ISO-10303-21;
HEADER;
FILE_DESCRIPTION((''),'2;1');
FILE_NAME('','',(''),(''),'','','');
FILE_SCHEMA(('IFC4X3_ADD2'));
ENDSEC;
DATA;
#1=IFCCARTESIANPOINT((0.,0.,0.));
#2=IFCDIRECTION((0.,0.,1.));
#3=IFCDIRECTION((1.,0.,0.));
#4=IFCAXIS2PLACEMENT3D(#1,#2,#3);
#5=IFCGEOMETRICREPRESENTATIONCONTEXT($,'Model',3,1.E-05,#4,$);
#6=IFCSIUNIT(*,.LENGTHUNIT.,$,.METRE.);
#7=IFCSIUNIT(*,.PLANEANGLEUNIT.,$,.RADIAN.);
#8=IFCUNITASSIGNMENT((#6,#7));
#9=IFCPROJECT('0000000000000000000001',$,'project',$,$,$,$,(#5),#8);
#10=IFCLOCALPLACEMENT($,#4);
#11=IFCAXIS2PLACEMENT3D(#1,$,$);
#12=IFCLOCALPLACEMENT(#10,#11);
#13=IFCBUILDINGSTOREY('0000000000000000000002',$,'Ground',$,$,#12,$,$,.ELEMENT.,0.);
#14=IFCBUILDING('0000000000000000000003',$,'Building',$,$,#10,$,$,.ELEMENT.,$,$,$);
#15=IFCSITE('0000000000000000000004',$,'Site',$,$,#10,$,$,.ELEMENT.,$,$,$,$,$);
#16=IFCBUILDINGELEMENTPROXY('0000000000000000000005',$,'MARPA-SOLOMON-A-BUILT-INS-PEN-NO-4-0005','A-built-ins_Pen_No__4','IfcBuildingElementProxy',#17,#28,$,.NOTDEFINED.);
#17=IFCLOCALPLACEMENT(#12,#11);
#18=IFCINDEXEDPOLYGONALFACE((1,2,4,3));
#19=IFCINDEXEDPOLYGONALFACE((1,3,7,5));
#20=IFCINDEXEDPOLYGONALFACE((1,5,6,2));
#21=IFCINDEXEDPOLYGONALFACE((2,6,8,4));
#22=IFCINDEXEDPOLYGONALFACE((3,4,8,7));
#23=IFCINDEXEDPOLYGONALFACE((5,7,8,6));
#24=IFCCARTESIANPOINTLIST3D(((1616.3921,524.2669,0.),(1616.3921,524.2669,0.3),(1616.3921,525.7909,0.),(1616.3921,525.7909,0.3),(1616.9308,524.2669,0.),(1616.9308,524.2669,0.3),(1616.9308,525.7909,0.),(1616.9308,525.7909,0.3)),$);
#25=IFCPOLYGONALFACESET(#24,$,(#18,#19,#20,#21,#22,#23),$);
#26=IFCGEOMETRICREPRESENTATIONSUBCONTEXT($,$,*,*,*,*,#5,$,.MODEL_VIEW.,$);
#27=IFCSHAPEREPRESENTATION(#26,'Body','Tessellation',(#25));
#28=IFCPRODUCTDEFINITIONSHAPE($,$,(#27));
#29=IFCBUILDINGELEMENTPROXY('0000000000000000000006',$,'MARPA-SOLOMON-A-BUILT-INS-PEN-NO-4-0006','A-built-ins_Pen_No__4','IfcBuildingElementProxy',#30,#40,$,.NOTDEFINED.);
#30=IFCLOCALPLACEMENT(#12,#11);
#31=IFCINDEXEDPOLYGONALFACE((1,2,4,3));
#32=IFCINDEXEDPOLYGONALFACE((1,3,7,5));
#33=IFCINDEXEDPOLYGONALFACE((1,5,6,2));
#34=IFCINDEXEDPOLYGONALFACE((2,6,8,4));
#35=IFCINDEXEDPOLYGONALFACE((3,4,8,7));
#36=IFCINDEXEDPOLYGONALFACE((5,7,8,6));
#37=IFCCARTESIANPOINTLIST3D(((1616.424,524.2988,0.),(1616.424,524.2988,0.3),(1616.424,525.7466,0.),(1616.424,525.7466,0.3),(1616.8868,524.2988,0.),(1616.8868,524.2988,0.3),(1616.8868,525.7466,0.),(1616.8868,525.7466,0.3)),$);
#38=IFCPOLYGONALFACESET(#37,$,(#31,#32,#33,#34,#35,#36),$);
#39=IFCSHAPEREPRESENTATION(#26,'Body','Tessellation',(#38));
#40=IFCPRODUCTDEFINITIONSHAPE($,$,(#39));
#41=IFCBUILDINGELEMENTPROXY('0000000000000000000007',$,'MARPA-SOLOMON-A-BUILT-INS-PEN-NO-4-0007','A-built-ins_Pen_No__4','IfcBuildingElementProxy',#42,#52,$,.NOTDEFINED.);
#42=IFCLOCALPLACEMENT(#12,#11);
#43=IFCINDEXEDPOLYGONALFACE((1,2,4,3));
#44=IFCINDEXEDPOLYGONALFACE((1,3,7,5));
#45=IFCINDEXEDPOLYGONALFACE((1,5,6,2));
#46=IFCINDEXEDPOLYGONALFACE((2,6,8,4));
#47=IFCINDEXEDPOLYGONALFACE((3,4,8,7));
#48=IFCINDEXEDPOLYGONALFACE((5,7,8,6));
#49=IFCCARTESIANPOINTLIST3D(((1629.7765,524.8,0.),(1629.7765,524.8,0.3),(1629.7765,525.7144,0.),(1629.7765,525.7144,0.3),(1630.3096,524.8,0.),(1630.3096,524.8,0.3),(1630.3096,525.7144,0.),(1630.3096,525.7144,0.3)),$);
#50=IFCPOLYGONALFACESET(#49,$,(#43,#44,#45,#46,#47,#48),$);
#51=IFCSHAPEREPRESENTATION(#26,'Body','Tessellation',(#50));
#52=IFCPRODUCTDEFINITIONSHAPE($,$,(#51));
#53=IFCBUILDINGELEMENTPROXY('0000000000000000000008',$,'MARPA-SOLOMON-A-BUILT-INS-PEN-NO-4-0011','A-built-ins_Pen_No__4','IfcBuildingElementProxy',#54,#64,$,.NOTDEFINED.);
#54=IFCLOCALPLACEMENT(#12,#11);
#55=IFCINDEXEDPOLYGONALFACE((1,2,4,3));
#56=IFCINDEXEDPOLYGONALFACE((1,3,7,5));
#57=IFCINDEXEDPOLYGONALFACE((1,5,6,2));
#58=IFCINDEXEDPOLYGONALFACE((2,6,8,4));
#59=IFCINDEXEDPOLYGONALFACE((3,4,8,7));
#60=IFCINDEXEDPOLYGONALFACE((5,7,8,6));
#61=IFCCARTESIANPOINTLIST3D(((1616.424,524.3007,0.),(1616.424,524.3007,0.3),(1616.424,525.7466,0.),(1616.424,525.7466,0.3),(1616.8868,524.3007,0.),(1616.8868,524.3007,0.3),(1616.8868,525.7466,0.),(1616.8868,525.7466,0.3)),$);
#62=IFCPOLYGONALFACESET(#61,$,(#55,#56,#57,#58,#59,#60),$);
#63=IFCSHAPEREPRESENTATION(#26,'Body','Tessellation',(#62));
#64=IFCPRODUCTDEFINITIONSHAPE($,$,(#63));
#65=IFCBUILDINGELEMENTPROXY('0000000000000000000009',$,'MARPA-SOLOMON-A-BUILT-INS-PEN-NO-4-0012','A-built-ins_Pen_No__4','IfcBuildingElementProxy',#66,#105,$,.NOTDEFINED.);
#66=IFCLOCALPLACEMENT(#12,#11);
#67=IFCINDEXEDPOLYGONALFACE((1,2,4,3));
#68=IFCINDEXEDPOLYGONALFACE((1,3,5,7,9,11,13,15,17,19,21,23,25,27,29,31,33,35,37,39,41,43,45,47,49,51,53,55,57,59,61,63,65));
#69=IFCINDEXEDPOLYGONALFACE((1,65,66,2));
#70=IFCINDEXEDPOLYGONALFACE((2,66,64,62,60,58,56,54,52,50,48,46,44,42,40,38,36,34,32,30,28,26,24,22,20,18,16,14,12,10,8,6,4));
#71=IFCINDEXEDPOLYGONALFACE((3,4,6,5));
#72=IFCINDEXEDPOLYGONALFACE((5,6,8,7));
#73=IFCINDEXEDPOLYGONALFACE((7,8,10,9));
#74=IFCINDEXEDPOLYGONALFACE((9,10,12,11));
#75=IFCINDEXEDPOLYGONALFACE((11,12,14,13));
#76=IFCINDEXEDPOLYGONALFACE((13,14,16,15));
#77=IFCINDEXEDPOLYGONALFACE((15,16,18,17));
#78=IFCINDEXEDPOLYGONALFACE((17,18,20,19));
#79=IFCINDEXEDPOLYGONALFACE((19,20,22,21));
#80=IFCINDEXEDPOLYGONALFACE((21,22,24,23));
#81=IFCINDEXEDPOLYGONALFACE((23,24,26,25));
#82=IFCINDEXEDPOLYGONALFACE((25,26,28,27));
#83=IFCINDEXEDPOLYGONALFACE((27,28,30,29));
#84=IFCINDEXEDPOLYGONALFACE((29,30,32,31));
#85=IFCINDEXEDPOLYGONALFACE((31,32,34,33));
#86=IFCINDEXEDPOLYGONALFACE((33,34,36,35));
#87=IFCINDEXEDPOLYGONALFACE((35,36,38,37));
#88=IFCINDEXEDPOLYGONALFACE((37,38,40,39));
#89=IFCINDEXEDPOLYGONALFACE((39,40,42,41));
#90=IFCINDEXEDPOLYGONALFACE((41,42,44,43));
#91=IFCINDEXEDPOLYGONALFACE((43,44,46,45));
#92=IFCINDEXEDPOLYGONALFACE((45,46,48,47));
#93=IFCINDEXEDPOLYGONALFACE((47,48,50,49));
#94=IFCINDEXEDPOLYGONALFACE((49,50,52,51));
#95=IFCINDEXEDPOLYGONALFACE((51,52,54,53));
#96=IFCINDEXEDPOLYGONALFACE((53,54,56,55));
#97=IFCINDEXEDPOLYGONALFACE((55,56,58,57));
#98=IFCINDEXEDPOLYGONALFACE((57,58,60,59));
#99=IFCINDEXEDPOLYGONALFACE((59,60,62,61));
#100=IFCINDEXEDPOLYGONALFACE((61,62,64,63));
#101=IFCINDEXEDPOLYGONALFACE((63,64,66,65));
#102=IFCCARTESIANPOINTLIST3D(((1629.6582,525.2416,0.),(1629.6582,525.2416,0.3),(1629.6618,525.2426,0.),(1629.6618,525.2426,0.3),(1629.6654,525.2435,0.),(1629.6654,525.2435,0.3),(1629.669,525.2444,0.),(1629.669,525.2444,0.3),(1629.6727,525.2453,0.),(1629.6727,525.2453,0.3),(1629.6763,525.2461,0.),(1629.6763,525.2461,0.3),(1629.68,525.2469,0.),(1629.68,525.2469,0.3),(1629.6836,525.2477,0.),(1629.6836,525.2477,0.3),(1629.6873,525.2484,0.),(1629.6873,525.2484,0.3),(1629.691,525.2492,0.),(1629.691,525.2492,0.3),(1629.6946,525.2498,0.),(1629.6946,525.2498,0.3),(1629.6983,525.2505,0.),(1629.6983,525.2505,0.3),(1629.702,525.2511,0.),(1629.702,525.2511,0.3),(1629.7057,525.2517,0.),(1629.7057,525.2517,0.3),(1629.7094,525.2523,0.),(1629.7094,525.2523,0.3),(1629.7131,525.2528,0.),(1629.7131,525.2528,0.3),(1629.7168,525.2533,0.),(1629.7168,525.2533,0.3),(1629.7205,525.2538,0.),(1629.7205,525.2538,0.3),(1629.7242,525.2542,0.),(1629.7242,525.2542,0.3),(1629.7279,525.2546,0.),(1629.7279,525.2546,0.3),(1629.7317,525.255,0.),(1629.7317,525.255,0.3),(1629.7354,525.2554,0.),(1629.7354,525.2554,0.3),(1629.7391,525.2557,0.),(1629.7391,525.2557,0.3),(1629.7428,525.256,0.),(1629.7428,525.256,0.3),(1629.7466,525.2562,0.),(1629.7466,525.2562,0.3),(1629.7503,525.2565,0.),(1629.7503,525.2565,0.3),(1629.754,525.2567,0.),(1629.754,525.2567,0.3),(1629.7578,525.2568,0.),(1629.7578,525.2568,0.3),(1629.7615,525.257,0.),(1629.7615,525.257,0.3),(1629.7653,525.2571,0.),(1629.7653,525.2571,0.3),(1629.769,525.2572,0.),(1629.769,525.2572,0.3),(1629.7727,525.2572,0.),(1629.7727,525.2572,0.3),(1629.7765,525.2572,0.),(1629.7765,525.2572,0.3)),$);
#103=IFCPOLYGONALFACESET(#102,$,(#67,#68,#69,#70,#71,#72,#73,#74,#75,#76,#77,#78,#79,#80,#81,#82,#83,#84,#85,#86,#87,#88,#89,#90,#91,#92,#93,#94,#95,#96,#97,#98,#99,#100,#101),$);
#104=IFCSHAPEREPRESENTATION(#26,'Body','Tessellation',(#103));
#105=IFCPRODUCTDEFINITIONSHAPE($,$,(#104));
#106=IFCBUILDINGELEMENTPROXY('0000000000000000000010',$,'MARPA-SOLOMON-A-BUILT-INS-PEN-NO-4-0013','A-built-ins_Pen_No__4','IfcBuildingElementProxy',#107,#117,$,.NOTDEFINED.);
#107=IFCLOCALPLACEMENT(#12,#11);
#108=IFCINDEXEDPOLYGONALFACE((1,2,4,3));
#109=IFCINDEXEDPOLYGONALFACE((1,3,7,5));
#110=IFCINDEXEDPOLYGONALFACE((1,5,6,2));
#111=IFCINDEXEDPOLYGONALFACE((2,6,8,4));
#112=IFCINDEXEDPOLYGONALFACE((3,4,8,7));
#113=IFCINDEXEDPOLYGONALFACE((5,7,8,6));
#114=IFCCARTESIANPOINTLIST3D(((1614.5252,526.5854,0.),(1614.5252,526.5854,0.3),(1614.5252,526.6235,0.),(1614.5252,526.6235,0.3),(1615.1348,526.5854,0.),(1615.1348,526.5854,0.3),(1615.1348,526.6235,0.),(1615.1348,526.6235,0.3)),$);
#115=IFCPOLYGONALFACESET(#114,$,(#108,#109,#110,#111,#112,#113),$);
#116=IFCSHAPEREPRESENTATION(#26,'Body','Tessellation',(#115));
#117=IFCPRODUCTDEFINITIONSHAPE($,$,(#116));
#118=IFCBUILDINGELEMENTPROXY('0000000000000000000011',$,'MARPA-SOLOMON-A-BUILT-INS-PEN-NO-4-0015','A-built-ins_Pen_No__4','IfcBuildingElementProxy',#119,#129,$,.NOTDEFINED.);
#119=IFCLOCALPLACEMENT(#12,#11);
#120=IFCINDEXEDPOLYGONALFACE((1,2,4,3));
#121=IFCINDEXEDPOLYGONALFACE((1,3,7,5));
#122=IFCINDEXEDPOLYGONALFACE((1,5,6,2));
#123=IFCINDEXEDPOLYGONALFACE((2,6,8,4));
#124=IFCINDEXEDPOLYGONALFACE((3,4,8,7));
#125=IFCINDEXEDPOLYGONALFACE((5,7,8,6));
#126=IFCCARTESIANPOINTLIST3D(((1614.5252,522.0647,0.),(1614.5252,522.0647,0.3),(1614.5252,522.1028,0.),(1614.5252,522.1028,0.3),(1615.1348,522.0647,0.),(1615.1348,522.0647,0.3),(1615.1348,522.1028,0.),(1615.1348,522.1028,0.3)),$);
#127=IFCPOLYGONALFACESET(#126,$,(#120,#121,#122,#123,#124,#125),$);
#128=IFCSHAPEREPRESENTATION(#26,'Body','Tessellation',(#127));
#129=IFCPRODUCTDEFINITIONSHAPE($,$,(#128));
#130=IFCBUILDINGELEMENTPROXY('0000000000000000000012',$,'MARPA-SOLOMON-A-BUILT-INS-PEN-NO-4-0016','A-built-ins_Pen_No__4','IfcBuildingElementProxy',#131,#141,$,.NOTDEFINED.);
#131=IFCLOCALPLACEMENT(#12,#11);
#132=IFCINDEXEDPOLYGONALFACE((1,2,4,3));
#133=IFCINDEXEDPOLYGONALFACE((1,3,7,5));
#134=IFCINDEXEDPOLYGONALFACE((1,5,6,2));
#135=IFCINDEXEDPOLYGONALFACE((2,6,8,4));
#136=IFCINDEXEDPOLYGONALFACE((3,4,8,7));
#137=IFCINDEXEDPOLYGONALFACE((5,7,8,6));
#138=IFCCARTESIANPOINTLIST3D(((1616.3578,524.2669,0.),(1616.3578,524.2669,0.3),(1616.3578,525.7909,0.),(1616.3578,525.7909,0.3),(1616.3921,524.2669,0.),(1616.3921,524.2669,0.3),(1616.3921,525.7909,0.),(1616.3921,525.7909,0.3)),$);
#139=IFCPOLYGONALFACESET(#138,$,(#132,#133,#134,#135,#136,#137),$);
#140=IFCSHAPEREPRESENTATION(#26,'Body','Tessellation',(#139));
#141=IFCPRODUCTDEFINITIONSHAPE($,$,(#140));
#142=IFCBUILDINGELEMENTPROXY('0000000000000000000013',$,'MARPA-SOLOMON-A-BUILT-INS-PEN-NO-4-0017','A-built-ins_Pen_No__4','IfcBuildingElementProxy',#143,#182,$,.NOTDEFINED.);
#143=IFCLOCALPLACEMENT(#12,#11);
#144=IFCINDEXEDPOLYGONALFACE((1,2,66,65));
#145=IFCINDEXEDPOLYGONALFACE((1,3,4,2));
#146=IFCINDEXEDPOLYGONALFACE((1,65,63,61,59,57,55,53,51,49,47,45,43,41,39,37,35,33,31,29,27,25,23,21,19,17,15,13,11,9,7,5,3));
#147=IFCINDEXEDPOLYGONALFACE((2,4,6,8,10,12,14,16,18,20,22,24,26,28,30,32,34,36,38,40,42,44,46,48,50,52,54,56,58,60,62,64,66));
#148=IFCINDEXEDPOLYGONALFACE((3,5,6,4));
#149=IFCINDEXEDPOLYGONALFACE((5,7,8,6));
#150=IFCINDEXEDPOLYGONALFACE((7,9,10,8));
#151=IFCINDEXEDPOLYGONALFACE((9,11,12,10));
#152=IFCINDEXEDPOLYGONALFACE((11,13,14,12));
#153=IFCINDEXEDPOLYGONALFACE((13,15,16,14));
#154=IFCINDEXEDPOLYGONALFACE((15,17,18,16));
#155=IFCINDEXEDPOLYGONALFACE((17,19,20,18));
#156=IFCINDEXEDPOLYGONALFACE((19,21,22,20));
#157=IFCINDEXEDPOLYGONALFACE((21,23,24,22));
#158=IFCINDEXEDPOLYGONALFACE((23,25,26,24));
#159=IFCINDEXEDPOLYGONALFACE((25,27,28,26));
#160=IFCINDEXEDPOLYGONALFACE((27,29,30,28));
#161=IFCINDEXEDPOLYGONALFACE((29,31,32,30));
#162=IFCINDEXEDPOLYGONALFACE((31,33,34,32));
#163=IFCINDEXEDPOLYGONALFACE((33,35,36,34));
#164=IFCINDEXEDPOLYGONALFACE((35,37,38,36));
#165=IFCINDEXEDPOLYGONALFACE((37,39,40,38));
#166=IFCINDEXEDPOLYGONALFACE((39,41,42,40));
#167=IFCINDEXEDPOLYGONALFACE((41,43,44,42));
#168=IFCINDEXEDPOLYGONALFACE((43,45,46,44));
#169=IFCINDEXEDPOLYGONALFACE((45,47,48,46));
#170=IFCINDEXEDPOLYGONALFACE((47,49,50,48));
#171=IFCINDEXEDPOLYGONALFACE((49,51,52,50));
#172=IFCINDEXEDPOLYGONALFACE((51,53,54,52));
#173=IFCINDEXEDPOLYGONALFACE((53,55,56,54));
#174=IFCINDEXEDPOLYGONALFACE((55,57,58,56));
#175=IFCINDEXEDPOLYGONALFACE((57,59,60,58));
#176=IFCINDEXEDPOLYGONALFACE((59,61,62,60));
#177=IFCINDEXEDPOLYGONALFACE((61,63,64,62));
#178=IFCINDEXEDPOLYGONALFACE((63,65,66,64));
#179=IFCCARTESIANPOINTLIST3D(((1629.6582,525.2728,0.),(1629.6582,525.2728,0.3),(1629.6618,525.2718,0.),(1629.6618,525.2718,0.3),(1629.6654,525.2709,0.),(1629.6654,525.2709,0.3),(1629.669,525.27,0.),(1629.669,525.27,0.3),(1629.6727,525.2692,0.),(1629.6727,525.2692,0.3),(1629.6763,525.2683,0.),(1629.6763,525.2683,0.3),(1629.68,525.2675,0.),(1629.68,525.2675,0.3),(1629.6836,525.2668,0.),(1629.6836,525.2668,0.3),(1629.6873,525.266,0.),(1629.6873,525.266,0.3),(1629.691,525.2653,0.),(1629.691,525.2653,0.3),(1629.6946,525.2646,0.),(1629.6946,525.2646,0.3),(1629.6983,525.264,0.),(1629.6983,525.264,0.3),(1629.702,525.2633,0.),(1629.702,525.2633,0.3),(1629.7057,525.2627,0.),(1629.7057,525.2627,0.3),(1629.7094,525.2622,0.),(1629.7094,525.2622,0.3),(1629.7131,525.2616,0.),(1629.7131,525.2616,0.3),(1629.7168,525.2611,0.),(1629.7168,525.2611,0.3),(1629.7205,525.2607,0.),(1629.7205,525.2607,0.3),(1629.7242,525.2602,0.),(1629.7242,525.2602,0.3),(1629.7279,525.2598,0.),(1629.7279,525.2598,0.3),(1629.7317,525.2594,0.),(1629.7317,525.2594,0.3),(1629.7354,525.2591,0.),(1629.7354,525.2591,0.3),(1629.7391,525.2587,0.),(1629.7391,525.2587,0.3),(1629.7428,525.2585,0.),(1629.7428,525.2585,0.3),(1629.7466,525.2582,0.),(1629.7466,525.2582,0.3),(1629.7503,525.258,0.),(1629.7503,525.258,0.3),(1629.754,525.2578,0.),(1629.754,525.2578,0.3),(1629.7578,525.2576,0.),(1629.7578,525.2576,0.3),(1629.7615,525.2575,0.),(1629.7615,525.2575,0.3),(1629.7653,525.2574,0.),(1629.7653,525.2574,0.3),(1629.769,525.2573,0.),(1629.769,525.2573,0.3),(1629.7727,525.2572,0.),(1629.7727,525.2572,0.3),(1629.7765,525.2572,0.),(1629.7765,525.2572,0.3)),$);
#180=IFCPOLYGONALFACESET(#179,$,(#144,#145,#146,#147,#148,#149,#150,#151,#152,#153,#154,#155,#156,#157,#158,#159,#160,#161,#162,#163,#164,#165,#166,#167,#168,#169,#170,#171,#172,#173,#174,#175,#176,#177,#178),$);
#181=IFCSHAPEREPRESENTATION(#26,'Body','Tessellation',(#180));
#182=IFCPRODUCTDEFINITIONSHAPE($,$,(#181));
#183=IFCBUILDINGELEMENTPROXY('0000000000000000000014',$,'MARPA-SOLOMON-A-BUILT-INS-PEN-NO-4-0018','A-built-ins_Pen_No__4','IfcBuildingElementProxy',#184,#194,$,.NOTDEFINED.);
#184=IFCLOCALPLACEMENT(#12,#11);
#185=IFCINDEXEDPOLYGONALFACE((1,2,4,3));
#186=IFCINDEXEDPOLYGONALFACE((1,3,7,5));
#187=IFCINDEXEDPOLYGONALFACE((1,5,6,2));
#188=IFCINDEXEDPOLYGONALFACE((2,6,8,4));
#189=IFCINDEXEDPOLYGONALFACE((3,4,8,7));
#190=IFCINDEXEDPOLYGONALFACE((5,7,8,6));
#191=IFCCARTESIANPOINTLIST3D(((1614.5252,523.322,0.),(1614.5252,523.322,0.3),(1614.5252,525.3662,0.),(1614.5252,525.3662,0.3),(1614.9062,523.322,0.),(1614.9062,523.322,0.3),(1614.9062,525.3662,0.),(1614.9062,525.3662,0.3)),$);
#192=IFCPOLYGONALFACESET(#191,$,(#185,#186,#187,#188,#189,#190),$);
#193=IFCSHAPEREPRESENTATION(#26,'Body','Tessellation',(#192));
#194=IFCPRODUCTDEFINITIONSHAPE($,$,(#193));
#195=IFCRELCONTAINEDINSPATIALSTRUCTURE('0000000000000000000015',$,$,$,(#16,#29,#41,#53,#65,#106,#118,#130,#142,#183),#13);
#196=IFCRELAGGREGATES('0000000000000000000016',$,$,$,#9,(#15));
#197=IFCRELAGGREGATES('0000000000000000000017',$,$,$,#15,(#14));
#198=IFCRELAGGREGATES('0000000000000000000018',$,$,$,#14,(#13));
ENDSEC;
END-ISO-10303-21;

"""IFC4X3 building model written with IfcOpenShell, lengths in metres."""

from ifc_helpers import new_model, si_unit, frame, origin, origin_with_axes, place, context, subcontext, project, spatial, polyline, outline, extrude, element, save


model = new_model("IFC4X3")

# Units and contexts
model_context = context("Model", 3, precision=1e-05, world=origin_with_axes())
sub_context = subcontext(model_context, None, None, "MODEL_VIEW")
ifc_project = project(units=[si_unit("LENGTHUNIT", "METRE"), si_unit("PLANEANGLEUNIT", "RADIAN")], contexts=[model_context])

# Site, building, storey
placement = place(None, origin_with_axes())
site = spatial("IfcSite", under=ifc_project, at=placement, Name="Site", CompositionType="ELEMENT")
building = spatial("IfcBuilding", under=site, at=placement, Name="Building", CompositionType="ELEMENT")
storey_placement = place(placement, origin())
storey = spatial("IfcBuildingStorey", under=building, at=storey_placement, Name="Ground", CompositionType="ELEMENT", Elevation=0.0)

# Building element proxies
proxy_1_placement = place(placement, frame((1616.3921, 524.2669, 0.0)))
element("IfcBuildingElementProxy", 1, at=proxy_1_placement, inside=storey, Name="MARPA-SOLOMON-A-BUILT-INS-PEN-NO-4-0005", Description="A-built-ins_Pen_No__4", ObjectType="IfcBuildingElementProxy", PredefinedType="NOTDEFINED", context=sub_context, shape_type="SweptSolid", body=[
    extrude(outline(polyline([(0.0, 0.0), (0.0, 1.524), (0.5387, 1.524), (0.5387, 0.0), (0.0, 0.0)])), origin(), (0.0, 0.0, 1.0), 0.3),
])
proxy_2_placement = place(placement, frame((1616.424, 524.2988, 0.0)))
element("IfcBuildingElementProxy", 2, at=proxy_2_placement, inside=storey, Name="MARPA-SOLOMON-A-BUILT-INS-PEN-NO-4-0006", Description="A-built-ins_Pen_No__4", ObjectType="IfcBuildingElementProxy", PredefinedType="NOTDEFINED", context=sub_context, shape_type="SweptSolid", body=[
    extrude(outline(polyline([(0.0, 0.0), (0.0, 1.4478), (0.4628, 1.4478), (0.4628, 0.0), (0.0, 0.0)])), origin(), (0.0, 0.0, 1.0), 0.3),
])
proxy_3_placement = place(placement, frame((1629.7765, 524.8, 0.0)))
element("IfcBuildingElementProxy", 3, at=proxy_3_placement, inside=storey, Name="MARPA-SOLOMON-A-BUILT-INS-PEN-NO-4-0007", Description="A-built-ins_Pen_No__4", ObjectType="IfcBuildingElementProxy", PredefinedType="NOTDEFINED", context=sub_context, shape_type="SweptSolid", body=[
    extrude(outline(polyline([(0.0, 0.9144), (0.0, 0.0), (0.5331, 0.0), (0.5331, 0.9144), (0.0, 0.9144)])), origin(), (0.0, 0.0, 1.0), 0.3),
])
proxy_4_placement = place(placement, frame((1616.424, 524.3007, 0.0)))
element("IfcBuildingElementProxy", 4, at=proxy_4_placement, inside=storey, Name="MARPA-SOLOMON-A-BUILT-INS-PEN-NO-4-0011", Description="A-built-ins_Pen_No__4", ObjectType="IfcBuildingElementProxy", PredefinedType="NOTDEFINED", context=sub_context, shape_type="SweptSolid", body=[
    extrude(outline(polyline([(0.0, 0.0), (0.0, 1.4459), (0.4628, 1.4459), (0.4628, 0.0), (0.0, 0.0)])), origin(), (0.0, 0.0, 1.0), 0.3),
])
proxy_5_placement = place(placement, frame((1629.6582, 525.2416, 0.0)))
element("IfcBuildingElementProxy", 5, at=proxy_5_placement, inside=storey, Name="MARPA-SOLOMON-A-BUILT-INS-PEN-NO-4-0012", Description="A-built-ins_Pen_No__4", ObjectType="IfcBuildingElementProxy", PredefinedType="NOTDEFINED", context=sub_context, shape_type="SweptSolid", body=[
    extrude(outline(polyline([(0.0, 0.0), (0.0036, 0.001), (0.0072, 0.0019), (0.0109, 0.0028), (0.0145, 0.0036), (0.0182, 0.0045), (0.0218, 0.0053), (0.0255, 0.006), (0.0291, 0.0068), (0.0328, 0.0075), (0.0365, 0.0082), (0.0402, 0.0088), (0.0439, 0.0095), (0.0475, 0.0101), (0.0512, 0.0106), (0.0549, 0.0112), (0.0587, 0.0117), (0.0624, 0.0121), (0.0661, 0.0126), (0.0698, 0.013), (0.0735, 0.0134), (0.0772, 0.0137), (0.081, 0.014), (0.0847, 0.0143), (0.0884, 0.0146), (0.0922, 0.0148), (0.0959, 0.015), (0.0996, 0.0152), (0.1034, 0.0153), (0.1071, 0.0154), (0.1109, 0.0155), (0.1146, 0.0156), (0.1183, 0.0156), (0.0, 0.0)])), origin(), (0.0, 0.0, 1.0), 0.3),
])
proxy_6_placement = place(placement, frame((1614.5252, 526.5854, 0.0)))
element("IfcBuildingElementProxy", 6, at=proxy_6_placement, inside=storey, Name="MARPA-SOLOMON-A-BUILT-INS-PEN-NO-4-0013", Description="A-built-ins_Pen_No__4", ObjectType="IfcBuildingElementProxy", PredefinedType="NOTDEFINED", context=sub_context, shape_type="SweptSolid", body=[
    extrude(outline(polyline([(0.6096, 0.0381), (0.6096, 0.0), (0.0, 0.0), (0.0, 0.0381), (0.6096, 0.0381)])), origin(), (0.0, 0.0, 1.0), 0.3),
])
proxy_7_placement = place(placement, frame((1614.5252, 522.0647, 0.0)))
element("IfcBuildingElementProxy", 7, at=proxy_7_placement, inside=storey, Name="MARPA-SOLOMON-A-BUILT-INS-PEN-NO-4-0015", Description="A-built-ins_Pen_No__4", ObjectType="IfcBuildingElementProxy", PredefinedType="NOTDEFINED", context=sub_context, shape_type="SweptSolid", body=[
    extrude(outline(polyline([(0.6096, 0.0), (0.6096, 0.0381), (0.0, 0.0381), (0.0, 0.0), (0.6096, 0.0)])), origin(), (0.0, 0.0, 1.0), 0.3),
])
proxy_8_placement = place(placement, frame((1616.3578, 524.2669, 0.0)))
element("IfcBuildingElementProxy", 8, at=proxy_8_placement, inside=storey, Name="MARPA-SOLOMON-A-BUILT-INS-PEN-NO-4-0016", Description="A-built-ins_Pen_No__4", ObjectType="IfcBuildingElementProxy", PredefinedType="NOTDEFINED", context=sub_context, shape_type="SweptSolid", body=[
    extrude(outline(polyline([(0.0, 0.0), (0.0, 1.524), (0.0343, 1.524), (0.0343, 0.0), (0.0, 0.0)])), origin(), (0.0, 0.0, 1.0), 0.3),
])
proxy_9_placement = place(placement, frame((1629.6582, 525.2572, 0.0)))
element("IfcBuildingElementProxy", 9, at=proxy_9_placement, inside=storey, Name="MARPA-SOLOMON-A-BUILT-INS-PEN-NO-4-0017", Description="A-built-ins_Pen_No__4", ObjectType="IfcBuildingElementProxy", PredefinedType="NOTDEFINED", context=sub_context, shape_type="SweptSolid", body=[
    extrude(outline(polyline([(0.1183, 0.0), (0.1146, 0.0), (0.1109, 0.0001), (0.1071, 0.0001), (0.1034, 0.0002), (0.0996, 0.0004), (0.0959, 0.0006), (0.0922, 0.0007), (0.0884, 0.001), (0.0847, 0.0012), (0.081, 0.0015), (0.0772, 0.0019), (0.0735, 0.0022), (0.0698, 0.0026), (0.0661, 0.003), (0.0624, 0.0034), (0.0587, 0.0039), (0.0549, 0.0044), (0.0512, 0.0049), (0.0475, 0.0055), (0.0439, 0.0061), (0.0402, 0.0067), (0.0365, 0.0074), (0.0328, 0.0081), (0.0291, 0.0088), (0.0255, 0.0095), (0.0218, 0.0103), (0.0182, 0.0111), (0.0145, 0.0119), (0.0109, 0.0128), (0.0072, 0.0137), (0.0036, 0.0146), (0.0, 0.0156), (0.1183, 0.0)])), origin(), (0.0, 0.0, 1.0), 0.3),
])
proxy_10_placement = place(placement, frame((1614.5252, 523.322, 0.0)))
element("IfcBuildingElementProxy", 10, at=proxy_10_placement, inside=storey, Name="MARPA-SOLOMON-A-BUILT-INS-PEN-NO-4-0018", Description="A-built-ins_Pen_No__4", ObjectType="IfcBuildingElementProxy", PredefinedType="NOTDEFINED", context=sub_context, shape_type="SweptSolid", body=[
    extrude(outline(polyline([(0.381, 0.0), (0.381, 2.0442), (0.0, 2.0442), (0.0, 0.0), (0.381, 0.0)])), origin(), (0.0, 0.0, 1.0), 0.3),
])

save(model, "model.ifc")
